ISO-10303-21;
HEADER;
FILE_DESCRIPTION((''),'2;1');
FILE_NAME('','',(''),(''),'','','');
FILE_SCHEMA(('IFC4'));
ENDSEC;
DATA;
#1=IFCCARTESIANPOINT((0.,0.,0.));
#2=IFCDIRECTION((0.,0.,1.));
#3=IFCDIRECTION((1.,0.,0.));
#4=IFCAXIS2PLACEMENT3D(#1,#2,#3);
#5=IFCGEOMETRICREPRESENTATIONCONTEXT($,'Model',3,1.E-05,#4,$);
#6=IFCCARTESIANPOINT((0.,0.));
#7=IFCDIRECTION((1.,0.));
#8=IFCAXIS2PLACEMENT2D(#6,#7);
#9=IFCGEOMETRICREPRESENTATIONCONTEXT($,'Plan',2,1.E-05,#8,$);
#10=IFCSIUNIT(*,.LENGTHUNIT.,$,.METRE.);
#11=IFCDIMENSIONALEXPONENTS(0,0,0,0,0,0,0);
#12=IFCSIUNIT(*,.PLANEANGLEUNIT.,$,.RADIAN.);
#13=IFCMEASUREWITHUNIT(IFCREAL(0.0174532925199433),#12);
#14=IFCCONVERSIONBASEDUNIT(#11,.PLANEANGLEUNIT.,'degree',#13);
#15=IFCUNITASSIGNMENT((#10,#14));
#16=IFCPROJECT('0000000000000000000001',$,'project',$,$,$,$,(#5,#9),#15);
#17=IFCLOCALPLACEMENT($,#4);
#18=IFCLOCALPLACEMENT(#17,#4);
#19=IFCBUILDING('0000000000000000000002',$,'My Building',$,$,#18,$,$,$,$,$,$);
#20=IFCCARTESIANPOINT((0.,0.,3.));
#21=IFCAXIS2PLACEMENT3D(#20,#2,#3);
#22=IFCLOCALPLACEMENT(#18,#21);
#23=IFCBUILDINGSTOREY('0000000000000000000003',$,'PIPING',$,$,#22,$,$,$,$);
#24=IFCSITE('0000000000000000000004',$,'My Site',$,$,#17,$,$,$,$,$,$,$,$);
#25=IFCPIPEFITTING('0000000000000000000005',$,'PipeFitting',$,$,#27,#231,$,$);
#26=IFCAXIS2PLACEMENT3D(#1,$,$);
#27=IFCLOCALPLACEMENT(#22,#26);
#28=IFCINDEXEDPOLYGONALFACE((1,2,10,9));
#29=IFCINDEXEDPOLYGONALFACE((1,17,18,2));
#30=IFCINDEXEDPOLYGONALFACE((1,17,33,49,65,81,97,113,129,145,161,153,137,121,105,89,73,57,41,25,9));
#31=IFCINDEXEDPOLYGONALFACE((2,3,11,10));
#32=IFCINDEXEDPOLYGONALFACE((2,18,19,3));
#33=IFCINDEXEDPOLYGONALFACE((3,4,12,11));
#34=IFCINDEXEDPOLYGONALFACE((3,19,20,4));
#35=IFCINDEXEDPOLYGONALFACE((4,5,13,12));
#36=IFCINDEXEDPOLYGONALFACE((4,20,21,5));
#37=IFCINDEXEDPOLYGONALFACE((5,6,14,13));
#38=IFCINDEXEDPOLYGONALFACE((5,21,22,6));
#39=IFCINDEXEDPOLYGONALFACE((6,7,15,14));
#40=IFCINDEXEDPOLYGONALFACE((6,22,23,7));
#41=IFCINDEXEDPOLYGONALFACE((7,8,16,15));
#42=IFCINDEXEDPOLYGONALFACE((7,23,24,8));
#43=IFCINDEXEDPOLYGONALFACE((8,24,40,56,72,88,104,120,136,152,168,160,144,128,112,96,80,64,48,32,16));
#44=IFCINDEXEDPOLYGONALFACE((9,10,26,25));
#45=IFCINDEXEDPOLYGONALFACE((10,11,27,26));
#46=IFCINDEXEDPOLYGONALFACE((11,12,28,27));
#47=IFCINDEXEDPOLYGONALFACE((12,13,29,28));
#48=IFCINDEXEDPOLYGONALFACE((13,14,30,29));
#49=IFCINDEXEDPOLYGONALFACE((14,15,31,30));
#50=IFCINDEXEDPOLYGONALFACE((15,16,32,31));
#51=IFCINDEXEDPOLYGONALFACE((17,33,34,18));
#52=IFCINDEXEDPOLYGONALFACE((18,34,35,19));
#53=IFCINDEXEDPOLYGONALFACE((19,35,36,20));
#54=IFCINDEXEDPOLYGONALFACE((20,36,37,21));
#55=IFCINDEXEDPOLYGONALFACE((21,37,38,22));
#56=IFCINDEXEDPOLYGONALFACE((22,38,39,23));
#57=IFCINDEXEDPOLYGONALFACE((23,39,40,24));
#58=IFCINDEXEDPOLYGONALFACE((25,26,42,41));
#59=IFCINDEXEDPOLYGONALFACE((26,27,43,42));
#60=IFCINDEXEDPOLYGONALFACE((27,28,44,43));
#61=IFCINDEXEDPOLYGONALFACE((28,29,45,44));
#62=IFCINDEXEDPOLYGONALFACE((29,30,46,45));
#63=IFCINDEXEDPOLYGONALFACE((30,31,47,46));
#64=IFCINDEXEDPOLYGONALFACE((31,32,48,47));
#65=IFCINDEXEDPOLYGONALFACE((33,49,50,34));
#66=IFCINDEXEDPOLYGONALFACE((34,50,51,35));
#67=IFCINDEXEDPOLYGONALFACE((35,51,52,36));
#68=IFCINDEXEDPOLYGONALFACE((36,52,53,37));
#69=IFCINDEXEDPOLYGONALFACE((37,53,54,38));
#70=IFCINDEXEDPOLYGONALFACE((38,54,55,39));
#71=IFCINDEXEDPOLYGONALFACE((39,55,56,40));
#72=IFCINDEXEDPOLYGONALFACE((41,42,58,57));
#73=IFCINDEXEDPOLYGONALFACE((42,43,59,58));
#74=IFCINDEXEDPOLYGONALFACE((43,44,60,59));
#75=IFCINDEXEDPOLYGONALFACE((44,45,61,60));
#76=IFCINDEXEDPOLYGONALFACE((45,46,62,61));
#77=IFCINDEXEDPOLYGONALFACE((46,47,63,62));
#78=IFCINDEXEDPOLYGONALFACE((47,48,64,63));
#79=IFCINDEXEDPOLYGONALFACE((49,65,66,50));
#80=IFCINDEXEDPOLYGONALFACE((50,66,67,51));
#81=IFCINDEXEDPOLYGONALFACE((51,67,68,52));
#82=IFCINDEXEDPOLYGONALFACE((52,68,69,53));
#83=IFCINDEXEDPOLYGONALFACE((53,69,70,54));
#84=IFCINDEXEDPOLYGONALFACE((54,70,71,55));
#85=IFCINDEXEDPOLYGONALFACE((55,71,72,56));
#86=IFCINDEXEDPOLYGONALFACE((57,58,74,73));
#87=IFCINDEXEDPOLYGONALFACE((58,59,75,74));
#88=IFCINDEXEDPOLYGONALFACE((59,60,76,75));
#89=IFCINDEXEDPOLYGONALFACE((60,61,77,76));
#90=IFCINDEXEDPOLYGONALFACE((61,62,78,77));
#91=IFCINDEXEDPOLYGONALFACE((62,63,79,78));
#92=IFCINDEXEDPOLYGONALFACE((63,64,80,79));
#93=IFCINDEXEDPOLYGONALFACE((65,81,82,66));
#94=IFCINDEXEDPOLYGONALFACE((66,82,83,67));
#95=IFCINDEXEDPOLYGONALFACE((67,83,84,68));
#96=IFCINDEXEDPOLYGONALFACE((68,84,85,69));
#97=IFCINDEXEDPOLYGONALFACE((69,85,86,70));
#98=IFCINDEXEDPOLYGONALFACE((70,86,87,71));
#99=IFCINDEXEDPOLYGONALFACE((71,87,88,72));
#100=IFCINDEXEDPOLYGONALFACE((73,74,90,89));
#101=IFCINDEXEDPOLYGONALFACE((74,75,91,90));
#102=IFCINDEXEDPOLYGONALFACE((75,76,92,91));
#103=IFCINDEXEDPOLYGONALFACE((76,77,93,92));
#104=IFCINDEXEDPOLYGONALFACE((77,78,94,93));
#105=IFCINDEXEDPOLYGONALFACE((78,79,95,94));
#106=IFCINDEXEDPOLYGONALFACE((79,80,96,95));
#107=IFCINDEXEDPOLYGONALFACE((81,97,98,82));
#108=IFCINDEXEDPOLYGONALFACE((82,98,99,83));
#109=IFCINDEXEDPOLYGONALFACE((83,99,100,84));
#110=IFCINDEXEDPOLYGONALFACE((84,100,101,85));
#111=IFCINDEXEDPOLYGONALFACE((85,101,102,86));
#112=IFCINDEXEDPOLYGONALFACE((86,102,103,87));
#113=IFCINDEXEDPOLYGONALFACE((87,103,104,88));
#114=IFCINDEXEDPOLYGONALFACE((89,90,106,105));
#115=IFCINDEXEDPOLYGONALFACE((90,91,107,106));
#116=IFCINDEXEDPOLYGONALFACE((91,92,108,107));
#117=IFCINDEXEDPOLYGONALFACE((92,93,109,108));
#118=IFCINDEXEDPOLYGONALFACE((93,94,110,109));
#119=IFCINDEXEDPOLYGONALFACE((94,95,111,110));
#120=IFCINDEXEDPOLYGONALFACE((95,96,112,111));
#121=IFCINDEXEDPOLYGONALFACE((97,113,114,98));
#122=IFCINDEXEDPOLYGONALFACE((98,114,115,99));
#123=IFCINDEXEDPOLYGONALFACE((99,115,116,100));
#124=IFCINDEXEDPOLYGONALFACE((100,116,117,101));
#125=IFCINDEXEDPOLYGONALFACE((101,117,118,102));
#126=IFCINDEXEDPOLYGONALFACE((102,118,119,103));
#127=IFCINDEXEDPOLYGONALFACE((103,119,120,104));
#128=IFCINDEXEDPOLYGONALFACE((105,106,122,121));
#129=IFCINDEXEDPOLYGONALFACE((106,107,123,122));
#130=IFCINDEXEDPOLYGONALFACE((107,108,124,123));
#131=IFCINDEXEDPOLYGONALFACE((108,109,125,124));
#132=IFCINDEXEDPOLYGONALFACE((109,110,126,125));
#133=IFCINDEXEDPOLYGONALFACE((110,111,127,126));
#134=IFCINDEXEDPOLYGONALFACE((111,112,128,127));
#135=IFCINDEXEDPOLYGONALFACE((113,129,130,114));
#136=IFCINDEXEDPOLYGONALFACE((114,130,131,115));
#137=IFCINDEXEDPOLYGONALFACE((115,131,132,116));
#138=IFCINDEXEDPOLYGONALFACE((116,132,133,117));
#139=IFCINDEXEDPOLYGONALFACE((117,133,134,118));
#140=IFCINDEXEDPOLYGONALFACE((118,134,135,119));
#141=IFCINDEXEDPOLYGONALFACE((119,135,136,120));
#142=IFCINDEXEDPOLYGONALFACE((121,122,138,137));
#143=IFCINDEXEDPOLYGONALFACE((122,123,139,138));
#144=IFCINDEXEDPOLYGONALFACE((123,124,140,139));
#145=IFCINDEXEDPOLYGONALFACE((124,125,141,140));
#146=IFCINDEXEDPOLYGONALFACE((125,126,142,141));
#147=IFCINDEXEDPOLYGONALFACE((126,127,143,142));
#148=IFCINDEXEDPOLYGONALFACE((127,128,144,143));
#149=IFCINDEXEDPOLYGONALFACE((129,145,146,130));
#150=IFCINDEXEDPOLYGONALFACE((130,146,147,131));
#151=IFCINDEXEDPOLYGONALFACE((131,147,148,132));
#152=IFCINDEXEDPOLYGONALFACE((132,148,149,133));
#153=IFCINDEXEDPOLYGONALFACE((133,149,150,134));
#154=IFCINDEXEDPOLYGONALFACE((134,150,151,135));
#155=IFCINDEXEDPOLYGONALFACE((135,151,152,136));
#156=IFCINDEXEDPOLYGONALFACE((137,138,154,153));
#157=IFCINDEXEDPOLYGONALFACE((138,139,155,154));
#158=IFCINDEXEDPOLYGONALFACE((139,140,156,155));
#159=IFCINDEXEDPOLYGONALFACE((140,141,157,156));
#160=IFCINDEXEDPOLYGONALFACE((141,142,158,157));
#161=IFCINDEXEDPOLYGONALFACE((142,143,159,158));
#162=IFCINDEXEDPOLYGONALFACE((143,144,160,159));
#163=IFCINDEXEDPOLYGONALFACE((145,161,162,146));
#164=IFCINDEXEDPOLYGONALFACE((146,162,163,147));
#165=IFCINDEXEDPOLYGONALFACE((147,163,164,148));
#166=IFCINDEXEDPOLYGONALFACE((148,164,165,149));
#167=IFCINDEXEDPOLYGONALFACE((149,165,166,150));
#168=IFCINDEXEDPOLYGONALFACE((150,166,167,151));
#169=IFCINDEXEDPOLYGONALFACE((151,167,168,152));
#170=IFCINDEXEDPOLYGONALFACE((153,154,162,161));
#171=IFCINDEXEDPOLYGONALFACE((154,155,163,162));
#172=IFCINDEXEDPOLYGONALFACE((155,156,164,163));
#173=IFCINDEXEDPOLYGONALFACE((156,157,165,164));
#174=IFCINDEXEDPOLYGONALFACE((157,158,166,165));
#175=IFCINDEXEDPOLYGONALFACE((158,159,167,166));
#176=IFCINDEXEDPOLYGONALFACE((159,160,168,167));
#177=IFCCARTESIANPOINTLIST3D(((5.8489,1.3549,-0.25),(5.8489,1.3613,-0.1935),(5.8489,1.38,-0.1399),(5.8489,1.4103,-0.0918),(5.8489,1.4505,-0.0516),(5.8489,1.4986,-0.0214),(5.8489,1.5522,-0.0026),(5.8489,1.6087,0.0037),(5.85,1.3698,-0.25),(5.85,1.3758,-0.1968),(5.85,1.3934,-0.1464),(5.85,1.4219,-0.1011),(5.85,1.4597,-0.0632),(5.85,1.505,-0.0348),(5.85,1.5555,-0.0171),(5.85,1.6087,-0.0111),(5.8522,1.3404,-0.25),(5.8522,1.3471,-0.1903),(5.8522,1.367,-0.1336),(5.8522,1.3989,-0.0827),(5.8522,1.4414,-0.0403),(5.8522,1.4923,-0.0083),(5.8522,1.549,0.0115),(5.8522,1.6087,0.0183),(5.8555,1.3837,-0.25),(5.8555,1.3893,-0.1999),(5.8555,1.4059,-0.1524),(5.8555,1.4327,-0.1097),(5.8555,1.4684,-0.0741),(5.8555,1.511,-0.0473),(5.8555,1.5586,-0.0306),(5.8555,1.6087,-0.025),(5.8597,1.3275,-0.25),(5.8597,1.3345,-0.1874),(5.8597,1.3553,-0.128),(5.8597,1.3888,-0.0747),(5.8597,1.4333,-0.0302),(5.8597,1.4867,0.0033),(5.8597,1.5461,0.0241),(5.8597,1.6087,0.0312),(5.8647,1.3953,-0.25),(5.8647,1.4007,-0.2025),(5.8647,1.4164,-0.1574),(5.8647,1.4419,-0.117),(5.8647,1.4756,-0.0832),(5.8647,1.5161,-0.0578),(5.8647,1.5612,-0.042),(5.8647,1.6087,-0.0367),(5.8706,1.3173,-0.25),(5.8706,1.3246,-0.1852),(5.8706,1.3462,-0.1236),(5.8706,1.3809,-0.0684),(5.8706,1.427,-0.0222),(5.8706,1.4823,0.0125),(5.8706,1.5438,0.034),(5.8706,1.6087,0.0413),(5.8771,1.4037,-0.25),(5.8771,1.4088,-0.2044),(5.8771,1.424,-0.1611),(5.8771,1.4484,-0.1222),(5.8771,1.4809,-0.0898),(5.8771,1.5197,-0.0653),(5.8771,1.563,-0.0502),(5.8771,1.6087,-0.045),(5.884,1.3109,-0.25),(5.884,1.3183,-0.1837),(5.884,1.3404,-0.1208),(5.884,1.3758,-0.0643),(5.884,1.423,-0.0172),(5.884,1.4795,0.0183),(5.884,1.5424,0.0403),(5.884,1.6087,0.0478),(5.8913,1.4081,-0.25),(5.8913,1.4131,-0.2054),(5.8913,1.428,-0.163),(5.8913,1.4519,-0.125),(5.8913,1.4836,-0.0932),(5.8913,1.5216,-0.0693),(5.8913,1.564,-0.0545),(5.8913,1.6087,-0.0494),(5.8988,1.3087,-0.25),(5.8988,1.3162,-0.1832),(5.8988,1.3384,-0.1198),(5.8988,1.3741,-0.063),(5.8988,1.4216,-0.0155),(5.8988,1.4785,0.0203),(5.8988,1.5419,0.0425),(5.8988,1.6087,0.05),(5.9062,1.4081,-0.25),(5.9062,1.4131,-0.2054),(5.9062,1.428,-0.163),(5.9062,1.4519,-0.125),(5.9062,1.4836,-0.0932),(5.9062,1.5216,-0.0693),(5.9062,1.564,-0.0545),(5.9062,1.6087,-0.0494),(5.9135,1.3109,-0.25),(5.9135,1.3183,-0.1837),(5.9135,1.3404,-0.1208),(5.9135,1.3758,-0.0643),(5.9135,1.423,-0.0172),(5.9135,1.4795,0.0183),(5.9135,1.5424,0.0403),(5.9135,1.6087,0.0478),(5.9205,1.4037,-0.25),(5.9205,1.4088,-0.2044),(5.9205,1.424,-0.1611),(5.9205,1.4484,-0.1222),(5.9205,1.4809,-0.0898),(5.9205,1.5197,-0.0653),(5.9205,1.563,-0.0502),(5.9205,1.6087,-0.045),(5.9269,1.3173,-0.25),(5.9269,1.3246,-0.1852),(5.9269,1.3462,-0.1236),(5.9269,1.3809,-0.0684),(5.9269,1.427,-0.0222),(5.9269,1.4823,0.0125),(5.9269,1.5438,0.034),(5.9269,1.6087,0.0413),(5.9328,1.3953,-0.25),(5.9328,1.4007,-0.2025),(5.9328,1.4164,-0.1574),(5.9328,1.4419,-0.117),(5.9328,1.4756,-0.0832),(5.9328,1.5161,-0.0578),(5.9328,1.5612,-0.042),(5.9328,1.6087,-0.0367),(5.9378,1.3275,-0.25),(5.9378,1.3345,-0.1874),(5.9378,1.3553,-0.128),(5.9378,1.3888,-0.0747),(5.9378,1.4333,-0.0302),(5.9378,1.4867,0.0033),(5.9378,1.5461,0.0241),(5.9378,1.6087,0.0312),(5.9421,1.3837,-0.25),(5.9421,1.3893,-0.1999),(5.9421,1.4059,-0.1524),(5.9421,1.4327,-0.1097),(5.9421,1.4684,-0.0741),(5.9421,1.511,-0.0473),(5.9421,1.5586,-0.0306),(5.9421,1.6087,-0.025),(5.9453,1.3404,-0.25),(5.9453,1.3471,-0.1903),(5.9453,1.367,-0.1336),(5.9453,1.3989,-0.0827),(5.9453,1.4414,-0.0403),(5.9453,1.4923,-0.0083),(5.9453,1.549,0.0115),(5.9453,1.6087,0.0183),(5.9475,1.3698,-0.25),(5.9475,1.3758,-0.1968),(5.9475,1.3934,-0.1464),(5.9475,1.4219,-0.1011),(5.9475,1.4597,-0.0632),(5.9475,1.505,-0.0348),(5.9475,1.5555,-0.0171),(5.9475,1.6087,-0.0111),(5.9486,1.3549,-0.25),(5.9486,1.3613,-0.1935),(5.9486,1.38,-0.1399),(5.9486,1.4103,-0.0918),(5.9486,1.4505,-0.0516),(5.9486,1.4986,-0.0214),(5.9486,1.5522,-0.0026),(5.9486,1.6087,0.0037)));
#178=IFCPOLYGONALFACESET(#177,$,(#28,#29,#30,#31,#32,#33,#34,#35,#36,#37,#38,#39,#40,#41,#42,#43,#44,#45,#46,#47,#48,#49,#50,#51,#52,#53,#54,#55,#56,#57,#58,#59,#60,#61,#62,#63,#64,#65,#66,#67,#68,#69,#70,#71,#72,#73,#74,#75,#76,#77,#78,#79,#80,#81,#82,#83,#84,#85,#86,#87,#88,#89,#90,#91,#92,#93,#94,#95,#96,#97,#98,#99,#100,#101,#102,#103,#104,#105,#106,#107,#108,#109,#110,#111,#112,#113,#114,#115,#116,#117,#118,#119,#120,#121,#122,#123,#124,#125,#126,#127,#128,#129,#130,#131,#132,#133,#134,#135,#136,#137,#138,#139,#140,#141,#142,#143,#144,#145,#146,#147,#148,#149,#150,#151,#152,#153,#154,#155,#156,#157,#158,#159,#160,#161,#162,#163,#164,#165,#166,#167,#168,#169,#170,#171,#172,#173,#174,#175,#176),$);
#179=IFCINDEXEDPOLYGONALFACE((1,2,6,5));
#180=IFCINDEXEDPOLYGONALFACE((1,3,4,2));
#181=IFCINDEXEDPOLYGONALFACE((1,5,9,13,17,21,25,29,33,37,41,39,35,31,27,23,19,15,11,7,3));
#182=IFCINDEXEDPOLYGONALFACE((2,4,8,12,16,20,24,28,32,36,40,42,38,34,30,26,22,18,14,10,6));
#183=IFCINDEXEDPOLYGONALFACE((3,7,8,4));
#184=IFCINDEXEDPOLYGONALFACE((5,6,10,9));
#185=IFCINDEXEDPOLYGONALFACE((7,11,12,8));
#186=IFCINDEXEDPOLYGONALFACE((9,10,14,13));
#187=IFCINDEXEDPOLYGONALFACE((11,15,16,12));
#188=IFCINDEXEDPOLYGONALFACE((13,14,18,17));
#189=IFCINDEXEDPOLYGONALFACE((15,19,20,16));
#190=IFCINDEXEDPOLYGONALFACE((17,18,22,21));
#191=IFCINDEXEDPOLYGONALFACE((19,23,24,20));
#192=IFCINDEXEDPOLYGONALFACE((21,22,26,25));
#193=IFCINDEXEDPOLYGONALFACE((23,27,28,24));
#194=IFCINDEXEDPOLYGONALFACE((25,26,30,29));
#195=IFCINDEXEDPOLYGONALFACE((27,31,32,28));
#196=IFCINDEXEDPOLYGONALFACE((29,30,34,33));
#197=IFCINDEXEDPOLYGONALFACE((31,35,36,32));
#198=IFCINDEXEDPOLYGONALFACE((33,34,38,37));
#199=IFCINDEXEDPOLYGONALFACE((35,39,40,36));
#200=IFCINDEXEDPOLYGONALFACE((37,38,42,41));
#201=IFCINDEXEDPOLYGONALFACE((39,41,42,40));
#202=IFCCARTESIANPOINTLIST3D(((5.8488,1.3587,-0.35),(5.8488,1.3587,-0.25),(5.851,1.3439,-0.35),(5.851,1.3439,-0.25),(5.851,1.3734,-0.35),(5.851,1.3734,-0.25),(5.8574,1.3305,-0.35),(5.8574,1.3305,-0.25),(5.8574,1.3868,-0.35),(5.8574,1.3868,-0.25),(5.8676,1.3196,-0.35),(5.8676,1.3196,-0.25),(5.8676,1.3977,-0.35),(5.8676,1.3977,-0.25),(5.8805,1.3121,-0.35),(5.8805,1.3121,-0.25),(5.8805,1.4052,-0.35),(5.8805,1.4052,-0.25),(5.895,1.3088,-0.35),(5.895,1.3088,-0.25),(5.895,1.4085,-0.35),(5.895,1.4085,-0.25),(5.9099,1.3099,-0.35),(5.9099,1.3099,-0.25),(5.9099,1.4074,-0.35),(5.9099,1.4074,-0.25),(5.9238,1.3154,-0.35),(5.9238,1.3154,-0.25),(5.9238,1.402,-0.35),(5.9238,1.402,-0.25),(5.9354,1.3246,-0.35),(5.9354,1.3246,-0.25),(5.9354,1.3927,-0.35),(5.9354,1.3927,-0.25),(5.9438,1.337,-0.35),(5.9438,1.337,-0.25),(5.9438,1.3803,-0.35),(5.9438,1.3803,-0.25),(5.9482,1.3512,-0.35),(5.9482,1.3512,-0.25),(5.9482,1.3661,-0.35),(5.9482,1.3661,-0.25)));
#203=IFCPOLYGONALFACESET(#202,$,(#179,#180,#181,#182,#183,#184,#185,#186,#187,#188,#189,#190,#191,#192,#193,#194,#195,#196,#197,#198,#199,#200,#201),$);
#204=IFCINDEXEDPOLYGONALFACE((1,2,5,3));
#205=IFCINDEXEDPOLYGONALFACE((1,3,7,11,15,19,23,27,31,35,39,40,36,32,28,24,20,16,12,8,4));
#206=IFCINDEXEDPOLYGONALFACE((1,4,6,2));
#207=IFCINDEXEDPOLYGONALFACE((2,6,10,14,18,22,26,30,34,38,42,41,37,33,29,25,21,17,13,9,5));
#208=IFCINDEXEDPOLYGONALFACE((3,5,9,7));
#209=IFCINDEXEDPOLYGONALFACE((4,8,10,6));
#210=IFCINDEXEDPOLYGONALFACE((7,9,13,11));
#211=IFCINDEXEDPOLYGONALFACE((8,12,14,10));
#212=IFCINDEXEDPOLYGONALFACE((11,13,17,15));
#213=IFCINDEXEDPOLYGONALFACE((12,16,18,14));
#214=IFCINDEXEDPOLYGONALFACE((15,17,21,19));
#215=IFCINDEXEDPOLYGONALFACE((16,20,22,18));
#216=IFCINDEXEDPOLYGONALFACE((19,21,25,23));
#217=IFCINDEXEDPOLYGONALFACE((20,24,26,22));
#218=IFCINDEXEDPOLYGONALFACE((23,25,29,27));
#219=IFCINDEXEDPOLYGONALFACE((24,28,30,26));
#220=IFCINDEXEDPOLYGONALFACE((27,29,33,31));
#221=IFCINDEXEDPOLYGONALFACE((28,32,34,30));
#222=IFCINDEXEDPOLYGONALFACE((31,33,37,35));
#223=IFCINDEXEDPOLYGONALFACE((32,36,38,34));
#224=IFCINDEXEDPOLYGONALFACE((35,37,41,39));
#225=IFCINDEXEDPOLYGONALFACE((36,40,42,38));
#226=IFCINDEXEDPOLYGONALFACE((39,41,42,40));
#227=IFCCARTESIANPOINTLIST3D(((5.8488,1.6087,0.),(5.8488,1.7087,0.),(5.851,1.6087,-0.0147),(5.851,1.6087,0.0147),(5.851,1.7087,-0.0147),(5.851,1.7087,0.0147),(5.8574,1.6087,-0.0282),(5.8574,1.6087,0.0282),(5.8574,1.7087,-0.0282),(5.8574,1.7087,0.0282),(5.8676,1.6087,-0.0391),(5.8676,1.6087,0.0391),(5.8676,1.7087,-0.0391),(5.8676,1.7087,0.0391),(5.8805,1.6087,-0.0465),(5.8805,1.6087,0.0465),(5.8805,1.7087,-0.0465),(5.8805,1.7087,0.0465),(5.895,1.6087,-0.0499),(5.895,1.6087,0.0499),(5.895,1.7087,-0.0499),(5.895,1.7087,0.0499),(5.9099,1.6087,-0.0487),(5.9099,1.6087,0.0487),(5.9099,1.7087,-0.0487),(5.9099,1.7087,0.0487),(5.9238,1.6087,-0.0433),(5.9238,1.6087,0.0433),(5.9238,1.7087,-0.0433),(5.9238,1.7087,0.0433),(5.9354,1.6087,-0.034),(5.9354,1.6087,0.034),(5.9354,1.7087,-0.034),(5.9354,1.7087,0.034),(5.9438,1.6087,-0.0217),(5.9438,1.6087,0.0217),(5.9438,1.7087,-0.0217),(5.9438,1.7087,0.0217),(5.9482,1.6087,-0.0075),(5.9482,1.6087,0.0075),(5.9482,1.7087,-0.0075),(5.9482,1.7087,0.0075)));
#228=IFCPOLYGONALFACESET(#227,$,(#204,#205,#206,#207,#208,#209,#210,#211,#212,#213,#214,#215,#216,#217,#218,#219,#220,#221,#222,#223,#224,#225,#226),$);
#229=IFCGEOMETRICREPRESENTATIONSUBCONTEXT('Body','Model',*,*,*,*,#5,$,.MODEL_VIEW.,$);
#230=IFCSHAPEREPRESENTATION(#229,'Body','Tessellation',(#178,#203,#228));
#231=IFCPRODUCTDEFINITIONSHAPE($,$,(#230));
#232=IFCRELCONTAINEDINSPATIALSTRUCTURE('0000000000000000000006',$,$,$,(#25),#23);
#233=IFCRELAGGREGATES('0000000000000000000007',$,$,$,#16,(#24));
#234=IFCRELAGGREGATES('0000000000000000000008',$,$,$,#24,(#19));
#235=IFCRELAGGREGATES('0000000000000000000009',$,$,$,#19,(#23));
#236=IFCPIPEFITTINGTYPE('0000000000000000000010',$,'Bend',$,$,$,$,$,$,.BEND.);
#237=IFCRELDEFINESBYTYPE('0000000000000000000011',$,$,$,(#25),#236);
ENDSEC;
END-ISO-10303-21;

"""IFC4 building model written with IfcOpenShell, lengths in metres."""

from ifc_helpers import new_model, entity, si_unit, converted_unit, frame, origin_with_axes, origin_2d_with_axis, place, context, subcontext, project, spatial, circle, extrude, source, transform, mapped, type_object, type_shapes, element, save


model = new_model("IFC4")

# Units and contexts
model_context = context("Model", 3, precision=1e-05, world=origin_with_axes())
plan_context = context("Plan", 2, precision=1e-05, world=origin_2d_with_axis())
body_context = subcontext(model_context, "Body", "Model", "MODEL_VIEW")
ifc_project = project(units=[si_unit("LENGTHUNIT", "METRE"), converted_unit("PLANEANGLEUNIT", "degree", entity("IfcReal", 0.0174532925199433), si_unit("PLANEANGLEUNIT", "RADIAN"), dimensions=[0, 0, 0, 0, 0, 0, 0])], contexts=[model_context, plan_context])

# Site, building, storey
site_placement = place(None, origin_with_axes())
site = spatial("IfcSite", under=ifc_project, at=site_placement, Name="My Site")
building_placement = place(site_placement, origin_with_axes())
building = spatial("IfcBuilding", under=site, at=building_placement, Name="My Building")
storey_placement = place(building_placement, frame((0.0, 0.0, 3.0), z_axis=(0.0, 0.0, 1.0), x_axis=(1.0, 0.0, 0.0)))
storey = spatial("IfcBuildingStorey", under=building, at=storey_placement, Name="PIPING")

# Pipe fitting
pipe_fitting_type_1 = type_object("IfcPipeFittingType", Name="Bend", PredefinedType="BEND")
shared_shape = source(origin_with_axes(), body_context, "Body", "SolidModel", [
    entity("IfcSweptDiskSolid", entity("IfcIndexedPolyCurve", entity("IfcCartesianPointList3D", [[0.0, 0.0, -0.1], [0.0, 0.0732, -0.2768], [0.0, 0.25, -0.35]]), [entity("IfcArcIndex", [1, 2, 3])]), 0.05),
    extrude(circle(Radius=0.05), origin_with_axes(), (0.0, 0.0, -1.0), 0.1),
    extrude(circle(Radius=0.05), frame((0.0, 0.25, -0.35), z_axis=(0.0, 1.0, 0.0), x_axis=(1.0, 0.0, 0.0)), (0.0, 0.0, 1.0), 0.1),
])
type_shapes(pipe_fitting_type_1, [shared_shape])
for number, where, z_axis, x_axis, name in (
    (1, (5.8988, 1.3587, -0.35), (0.0, 0.0, -1.0), (-1.0, 0.0, 0.0), "PipeFitting"),
):
    element("IfcPipeFitting", number, at=place(storey_placement, frame(where, z_axis=z_axis, x_axis=x_axis)), inside=storey, type_object=pipe_fitting_type_1, Name=name, context=body_context, shape_type="MappedRepresentation", body=[
        mapped(shared_shape, transform((0.0, 0.0, 0.0), x_axis=(1.0, 0.0, 0.0), y_axis=(0.0, 1.0, 0.0), z_axis=(0.0, 0.0, 1.0), scale=1.0)),
    ])

save(model, "model.ifc")
